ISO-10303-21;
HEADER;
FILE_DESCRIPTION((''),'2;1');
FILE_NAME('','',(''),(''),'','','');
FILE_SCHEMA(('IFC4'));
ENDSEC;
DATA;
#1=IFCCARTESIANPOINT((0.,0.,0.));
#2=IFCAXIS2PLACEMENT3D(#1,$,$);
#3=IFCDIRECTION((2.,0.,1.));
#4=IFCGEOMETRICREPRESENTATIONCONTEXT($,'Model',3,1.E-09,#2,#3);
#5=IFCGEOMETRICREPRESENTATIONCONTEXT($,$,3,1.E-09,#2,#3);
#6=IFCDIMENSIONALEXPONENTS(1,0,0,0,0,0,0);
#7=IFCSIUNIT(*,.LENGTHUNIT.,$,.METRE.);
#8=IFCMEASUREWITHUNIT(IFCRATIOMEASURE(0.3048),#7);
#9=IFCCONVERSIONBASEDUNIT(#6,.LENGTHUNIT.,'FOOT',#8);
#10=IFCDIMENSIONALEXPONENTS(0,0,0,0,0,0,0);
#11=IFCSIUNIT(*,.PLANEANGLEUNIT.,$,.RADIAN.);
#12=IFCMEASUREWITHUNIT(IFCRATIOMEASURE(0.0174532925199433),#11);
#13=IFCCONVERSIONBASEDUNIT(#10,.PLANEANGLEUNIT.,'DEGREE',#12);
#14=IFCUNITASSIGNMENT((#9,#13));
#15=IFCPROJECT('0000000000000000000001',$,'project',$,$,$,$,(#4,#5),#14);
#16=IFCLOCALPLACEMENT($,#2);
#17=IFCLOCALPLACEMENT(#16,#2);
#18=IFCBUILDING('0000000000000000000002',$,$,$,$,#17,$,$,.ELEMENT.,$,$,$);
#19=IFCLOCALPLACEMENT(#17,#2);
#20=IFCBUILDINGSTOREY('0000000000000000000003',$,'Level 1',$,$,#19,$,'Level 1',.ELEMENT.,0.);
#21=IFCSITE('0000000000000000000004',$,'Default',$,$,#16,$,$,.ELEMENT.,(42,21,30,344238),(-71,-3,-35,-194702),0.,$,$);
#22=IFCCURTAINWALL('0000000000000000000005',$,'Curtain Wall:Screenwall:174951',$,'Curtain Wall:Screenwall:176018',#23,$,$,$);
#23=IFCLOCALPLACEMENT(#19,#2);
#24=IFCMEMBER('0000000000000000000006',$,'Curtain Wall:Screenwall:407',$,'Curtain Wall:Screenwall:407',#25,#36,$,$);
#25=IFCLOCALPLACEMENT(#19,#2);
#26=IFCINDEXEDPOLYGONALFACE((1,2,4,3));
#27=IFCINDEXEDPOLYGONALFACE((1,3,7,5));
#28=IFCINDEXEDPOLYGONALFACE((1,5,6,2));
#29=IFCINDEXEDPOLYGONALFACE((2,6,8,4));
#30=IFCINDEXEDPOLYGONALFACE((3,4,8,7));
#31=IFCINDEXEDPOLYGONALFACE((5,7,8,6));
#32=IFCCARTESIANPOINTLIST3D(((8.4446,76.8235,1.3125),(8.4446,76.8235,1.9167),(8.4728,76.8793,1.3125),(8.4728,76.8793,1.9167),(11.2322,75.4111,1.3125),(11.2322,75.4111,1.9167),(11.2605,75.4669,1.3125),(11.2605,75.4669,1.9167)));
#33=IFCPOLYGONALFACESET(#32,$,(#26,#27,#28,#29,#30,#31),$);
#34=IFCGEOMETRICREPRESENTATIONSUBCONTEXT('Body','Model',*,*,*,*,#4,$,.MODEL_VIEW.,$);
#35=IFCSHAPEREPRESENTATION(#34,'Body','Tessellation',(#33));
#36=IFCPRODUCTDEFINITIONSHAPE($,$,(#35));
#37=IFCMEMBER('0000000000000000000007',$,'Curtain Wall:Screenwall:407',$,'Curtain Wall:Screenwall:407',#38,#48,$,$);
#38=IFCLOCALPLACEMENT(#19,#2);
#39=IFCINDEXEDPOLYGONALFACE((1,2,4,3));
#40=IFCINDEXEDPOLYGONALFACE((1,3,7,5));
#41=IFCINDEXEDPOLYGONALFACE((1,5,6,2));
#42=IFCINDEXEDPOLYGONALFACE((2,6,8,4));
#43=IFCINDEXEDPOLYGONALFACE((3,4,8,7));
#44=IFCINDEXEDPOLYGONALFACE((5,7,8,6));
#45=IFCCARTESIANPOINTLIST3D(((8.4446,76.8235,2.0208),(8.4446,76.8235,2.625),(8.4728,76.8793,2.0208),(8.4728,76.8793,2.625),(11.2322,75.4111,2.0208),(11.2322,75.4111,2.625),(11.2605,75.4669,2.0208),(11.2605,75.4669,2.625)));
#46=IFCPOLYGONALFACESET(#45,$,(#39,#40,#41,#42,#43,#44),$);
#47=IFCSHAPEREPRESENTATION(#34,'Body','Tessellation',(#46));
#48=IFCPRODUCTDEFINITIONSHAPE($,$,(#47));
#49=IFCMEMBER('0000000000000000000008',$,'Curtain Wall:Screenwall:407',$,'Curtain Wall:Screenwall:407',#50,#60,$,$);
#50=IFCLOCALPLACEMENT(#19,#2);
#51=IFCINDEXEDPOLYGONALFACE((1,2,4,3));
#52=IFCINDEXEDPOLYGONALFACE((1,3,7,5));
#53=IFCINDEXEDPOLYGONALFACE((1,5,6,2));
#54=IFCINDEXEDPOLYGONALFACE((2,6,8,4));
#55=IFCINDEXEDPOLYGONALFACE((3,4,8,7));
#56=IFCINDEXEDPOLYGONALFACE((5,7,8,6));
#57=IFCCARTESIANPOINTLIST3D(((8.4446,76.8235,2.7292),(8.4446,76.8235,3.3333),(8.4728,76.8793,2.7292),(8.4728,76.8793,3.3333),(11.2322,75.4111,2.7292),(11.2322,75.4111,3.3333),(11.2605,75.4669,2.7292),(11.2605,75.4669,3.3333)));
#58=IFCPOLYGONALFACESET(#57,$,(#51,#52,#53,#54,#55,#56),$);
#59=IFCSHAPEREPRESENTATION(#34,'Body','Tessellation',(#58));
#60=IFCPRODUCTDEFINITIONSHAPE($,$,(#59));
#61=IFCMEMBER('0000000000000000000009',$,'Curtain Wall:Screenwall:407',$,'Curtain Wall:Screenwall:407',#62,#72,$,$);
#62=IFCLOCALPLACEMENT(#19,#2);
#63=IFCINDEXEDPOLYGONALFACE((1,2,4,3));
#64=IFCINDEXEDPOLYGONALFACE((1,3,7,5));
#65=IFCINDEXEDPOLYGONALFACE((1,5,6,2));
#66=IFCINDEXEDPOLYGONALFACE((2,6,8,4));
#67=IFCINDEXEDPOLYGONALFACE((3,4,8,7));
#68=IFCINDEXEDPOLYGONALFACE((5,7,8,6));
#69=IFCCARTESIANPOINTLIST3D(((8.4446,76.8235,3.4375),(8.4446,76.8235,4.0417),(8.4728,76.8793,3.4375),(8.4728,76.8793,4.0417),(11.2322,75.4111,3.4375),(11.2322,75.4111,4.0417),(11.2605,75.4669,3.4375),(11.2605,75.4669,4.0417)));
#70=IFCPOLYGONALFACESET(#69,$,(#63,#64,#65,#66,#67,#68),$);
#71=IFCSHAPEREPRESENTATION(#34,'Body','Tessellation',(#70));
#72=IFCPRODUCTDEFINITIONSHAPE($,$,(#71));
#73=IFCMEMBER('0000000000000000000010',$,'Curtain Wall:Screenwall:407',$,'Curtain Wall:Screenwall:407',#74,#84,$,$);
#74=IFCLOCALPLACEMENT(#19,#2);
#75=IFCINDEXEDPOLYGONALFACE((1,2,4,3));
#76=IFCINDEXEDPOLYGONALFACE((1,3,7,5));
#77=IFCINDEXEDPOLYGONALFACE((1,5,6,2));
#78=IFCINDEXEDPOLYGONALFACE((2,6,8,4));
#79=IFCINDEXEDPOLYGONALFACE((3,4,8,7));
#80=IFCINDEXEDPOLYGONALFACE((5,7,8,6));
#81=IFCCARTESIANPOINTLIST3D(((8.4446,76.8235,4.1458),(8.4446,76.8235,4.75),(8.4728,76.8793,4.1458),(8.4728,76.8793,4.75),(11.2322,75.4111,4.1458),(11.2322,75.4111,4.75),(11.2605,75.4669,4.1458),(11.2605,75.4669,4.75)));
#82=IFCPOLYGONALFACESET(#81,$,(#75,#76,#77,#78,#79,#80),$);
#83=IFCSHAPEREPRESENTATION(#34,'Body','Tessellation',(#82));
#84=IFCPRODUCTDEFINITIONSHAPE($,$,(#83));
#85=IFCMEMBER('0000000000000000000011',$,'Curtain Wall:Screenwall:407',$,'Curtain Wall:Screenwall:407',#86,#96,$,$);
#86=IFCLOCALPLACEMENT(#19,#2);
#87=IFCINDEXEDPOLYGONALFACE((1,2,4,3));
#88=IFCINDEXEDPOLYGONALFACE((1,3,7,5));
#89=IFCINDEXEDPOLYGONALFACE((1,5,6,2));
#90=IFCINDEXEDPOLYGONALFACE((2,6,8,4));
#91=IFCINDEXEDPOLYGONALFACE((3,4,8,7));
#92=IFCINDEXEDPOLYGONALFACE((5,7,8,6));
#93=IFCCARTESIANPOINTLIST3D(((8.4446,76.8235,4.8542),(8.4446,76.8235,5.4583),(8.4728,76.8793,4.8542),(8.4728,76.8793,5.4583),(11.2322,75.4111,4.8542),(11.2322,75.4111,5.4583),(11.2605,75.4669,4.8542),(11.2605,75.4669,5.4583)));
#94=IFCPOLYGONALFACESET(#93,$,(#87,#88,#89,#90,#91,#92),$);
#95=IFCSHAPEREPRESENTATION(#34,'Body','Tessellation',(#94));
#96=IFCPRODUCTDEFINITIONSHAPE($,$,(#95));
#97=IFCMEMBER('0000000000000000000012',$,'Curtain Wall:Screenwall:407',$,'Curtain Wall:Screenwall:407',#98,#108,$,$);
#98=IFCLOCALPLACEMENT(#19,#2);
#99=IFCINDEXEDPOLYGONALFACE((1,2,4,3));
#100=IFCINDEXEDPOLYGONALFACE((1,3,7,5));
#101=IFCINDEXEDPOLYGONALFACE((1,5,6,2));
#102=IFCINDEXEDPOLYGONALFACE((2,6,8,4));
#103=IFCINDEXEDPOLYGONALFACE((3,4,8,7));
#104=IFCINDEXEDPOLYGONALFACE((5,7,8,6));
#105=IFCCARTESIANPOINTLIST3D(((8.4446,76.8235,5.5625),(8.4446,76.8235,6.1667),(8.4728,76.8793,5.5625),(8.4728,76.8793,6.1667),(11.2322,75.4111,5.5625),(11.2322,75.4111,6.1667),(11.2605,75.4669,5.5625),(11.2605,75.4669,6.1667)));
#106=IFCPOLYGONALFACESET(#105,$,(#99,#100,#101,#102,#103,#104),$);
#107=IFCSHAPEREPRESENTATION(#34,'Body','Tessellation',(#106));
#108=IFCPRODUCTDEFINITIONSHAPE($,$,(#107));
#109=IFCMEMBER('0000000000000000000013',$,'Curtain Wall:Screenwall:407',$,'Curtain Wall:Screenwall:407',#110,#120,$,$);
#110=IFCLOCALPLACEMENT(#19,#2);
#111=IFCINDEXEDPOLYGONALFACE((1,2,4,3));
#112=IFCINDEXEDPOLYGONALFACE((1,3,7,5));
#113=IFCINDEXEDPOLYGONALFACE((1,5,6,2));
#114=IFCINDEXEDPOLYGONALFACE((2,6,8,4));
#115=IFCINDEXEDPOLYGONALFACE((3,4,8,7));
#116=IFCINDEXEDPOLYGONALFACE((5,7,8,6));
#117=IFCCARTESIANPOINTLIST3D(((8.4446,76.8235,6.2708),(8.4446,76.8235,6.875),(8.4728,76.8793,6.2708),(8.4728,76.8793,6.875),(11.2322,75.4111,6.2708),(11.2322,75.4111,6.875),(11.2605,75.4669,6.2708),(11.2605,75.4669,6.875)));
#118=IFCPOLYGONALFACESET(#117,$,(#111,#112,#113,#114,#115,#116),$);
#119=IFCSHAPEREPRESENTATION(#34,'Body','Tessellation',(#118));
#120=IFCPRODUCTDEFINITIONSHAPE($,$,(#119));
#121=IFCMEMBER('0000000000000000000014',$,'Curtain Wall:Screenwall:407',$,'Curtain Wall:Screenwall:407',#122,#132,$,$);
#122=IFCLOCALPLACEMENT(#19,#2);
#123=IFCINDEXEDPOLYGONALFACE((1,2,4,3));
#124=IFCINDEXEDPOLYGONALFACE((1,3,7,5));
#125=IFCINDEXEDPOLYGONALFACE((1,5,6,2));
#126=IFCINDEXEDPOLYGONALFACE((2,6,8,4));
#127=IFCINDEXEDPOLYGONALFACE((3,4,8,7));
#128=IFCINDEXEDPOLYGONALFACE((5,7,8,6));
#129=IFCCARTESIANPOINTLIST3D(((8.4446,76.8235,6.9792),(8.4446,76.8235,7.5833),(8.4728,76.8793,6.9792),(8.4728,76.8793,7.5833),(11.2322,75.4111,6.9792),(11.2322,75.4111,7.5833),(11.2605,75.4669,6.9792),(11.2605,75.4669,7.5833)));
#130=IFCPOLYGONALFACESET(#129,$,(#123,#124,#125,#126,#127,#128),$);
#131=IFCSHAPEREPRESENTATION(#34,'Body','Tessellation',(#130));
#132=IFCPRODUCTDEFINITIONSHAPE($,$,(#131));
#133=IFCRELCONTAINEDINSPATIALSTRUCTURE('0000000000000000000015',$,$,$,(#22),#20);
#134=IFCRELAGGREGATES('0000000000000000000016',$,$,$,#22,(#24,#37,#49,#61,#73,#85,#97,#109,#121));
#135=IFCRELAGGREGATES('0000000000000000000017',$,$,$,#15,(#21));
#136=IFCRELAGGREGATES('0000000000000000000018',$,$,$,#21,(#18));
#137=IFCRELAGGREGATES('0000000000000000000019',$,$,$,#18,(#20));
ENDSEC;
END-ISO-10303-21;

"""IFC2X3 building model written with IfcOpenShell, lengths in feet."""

from ifc_helpers import new_model, entity, si_unit, converted_unit, direction, frame, frame_2d, origin, place, context, subcontext, project, spatial, rectangle, extrude, element, aggregate, save


model = new_model("IFC2X3")

# Units and contexts
model_context = context("Model", 3, precision=1e-09, world=origin(), true_north=direction((2.0, 0.0, 1.0)))
context_of_model = context(None, 3, precision=1e-09, world=origin(), true_north=direction((2.0, 0.0, 1.0)))
body_context = subcontext(model_context, "Body", "Model", "MODEL_VIEW")
ifc_project = project(units=[converted_unit("LENGTHUNIT", "FOOT", entity("IfcRatioMeasure", 0.3048), si_unit("LENGTHUNIT", "METRE"), dimensions=[1, 0, 0, 0, 0, 0, 0]), converted_unit("PLANEANGLEUNIT", "DEGREE", entity("IfcRatioMeasure", 0.0174532925199433), si_unit("PLANEANGLEUNIT", "RADIAN"), dimensions=[0, 0, 0, 0, 0, 0, 0])], contexts=[model_context, context_of_model])

# Site, building, storey
site_placement = place(None, origin())
site = spatial("IfcSite", under=ifc_project, at=site_placement, Name="Default", CompositionType="ELEMENT", RefLatitude=(42, 21, 30, 344238), RefLongitude=(-71, -3, -35, -194702), RefElevation=0.0)
building_placement = place(site_placement, origin())
building = spatial("IfcBuilding", under=site, at=building_placement, CompositionType="ELEMENT")
storey_placement = place(building_placement, origin())
storey = spatial("IfcBuildingStorey", under=building, at=storey_placement, Name="Level 1", LongName="Level 1", CompositionType="ELEMENT", Elevation=0.0)

# Curtain wall, members
curtain_wall_placement = place(storey_placement, origin())
curtain_wall = element("IfcCurtainWall", 1, at=curtain_wall_placement, inside=storey, Name="Curtain Wall:Screenwall:174951", ObjectType="Curtain Wall:Screenwall:176018")
member_1_placement = place(curtain_wall_placement, frame((8.4446, 75.4111, 1.3125)))
member_1 = element("IfcMember", 2, at=member_1_placement, Name="Curtain Wall:Screenwall:407", ObjectType="Curtain Wall:Screenwall:407", context=body_context, shape_type="SweptSolid", body=[
    extrude(rectangle(XDim=3.1251, YDim=0.0625, at=frame_2d((0.0, 0.0), x_axis=(1.0, 0.0))), frame((1.408, 0.7341, 0.0), z_axis=(0.0, 0.0, 1.0), x_axis=(0.892035, -0.451966, 0.0)), (0.0, 0.0, 1.0), 0.6042),
])
member_2_placement = place(curtain_wall_placement, frame((8.4446, 75.4111, 2.0208)))
member_2 = element("IfcMember", 3, at=member_2_placement, Name="Curtain Wall:Screenwall:407", ObjectType="Curtain Wall:Screenwall:407", context=body_context, shape_type="SweptSolid", body=[
    extrude(rectangle(XDim=3.1251, YDim=0.0625, at=frame_2d((0.0, 0.0), x_axis=(1.0, 0.0))), frame((1.408, 0.7341, 0.0), z_axis=(0.0, 0.0, 1.0), x_axis=(0.892035, -0.451966, 0.0)), (0.0, 0.0, 1.0), 0.6042),
])
member_3_placement = place(curtain_wall_placement, frame((8.4446, 75.4111, 2.7292)))
member_3 = element("IfcMember", 4, at=member_3_placement, Name="Curtain Wall:Screenwall:407", ObjectType="Curtain Wall:Screenwall:407", context=body_context, shape_type="SweptSolid", body=[
    extrude(rectangle(XDim=3.1251, YDim=0.0625, at=frame_2d((0.0, 0.0), x_axis=(1.0, 0.0))), frame((1.408, 0.7341, 0.0), z_axis=(0.0, 0.0, 1.0), x_axis=(0.892035, -0.451966, 0.0)), (0.0, 0.0, 1.0), 0.6042),
])
member_4_placement = place(curtain_wall_placement, frame((8.4446, 75.4111, 3.4375)))
member_4 = element("IfcMember", 5, at=member_4_placement, Name="Curtain Wall:Screenwall:407", ObjectType="Curtain Wall:Screenwall:407", context=body_context, shape_type="SweptSolid", body=[
    extrude(rectangle(XDim=3.1251, YDim=0.0625, at=frame_2d((0.0, 0.0), x_axis=(1.0, 0.0))), frame((1.408, 0.7341, 0.0), z_axis=(0.0, 0.0, 1.0), x_axis=(0.892035, -0.451966, 0.0)), (0.0, 0.0, 1.0), 0.6042),
])
member_5_placement = place(curtain_wall_placement, frame((8.4446, 75.4111, 4.1458)))
member_5 = element("IfcMember", 6, at=member_5_placement, Name="Curtain Wall:Screenwall:407", ObjectType="Curtain Wall:Screenwall:407", context=body_context, shape_type="SweptSolid", body=[
    extrude(rectangle(XDim=3.1251, YDim=0.0625, at=frame_2d((0.0, 0.0), x_axis=(1.0, 0.0))), frame((1.408, 0.7341, 0.0), z_axis=(0.0, 0.0, 1.0), x_axis=(0.892035, -0.451966, 0.0)), (0.0, 0.0, 1.0), 0.6042),
])
member_6_placement = place(curtain_wall_placement, frame((8.4446, 75.4111, 4.8542)))
member_6 = element("IfcMember", 7, at=member_6_placement, Name="Curtain Wall:Screenwall:407", ObjectType="Curtain Wall:Screenwall:407", context=body_context, shape_type="SweptSolid", body=[
    extrude(rectangle(XDim=3.1251, YDim=0.0625, at=frame_2d((0.0, 0.0), x_axis=(1.0, 0.0))), frame((1.408, 0.7341, 0.0), z_axis=(0.0, 0.0, 1.0), x_axis=(0.892035, -0.451966, 0.0)), (0.0, 0.0, 1.0), 0.6042),
])
member_7_placement = place(curtain_wall_placement, frame((8.4446, 75.4111, 5.5625)))
member_7 = element("IfcMember", 8, at=member_7_placement, Name="Curtain Wall:Screenwall:407", ObjectType="Curtain Wall:Screenwall:407", context=body_context, shape_type="SweptSolid", body=[
    extrude(rectangle(XDim=3.1251, YDim=0.0625, at=frame_2d((0.0, 0.0), x_axis=(1.0, 0.0))), frame((1.408, 0.7341, 0.0), z_axis=(0.0, 0.0, 1.0), x_axis=(0.892035, -0.451966, 0.0)), (0.0, 0.0, 1.0), 0.6042),
])
member_8_placement = place(curtain_wall_placement, frame((8.4446, 75.4111, 6.2708)))
member_8 = element("IfcMember", 9, at=member_8_placement, Name="Curtain Wall:Screenwall:407", ObjectType="Curtain Wall:Screenwall:407", context=body_context, shape_type="SweptSolid", body=[
    extrude(rectangle(XDim=3.1251, YDim=0.0625, at=frame_2d((0.0, 0.0), x_axis=(1.0, 0.0))), frame((1.408, 0.7341, 0.0), z_axis=(0.0, 0.0, 1.0), x_axis=(0.892035, -0.451966, 0.0)), (0.0, 0.0, 1.0), 0.6042),
])
member_9_placement = place(curtain_wall_placement, frame((8.4446, 75.4111, 6.9792)))
member_9 = element("IfcMember", 10, at=member_9_placement, Name="Curtain Wall:Screenwall:407", ObjectType="Curtain Wall:Screenwall:407", context=body_context, shape_type="SweptSolid", body=[
    extrude(rectangle(XDim=3.1251, YDim=0.0625, at=frame_2d((0.0, 0.0), x_axis=(1.0, 0.0))), frame((1.408, 0.7341, 0.0), z_axis=(0.0, 0.0, 1.0), x_axis=(0.892035, -0.451966, 0.0)), (0.0, 0.0, 1.0), 0.6042),
])
aggregate(curtain_wall, [member_1, member_2, member_3, member_4, member_5, member_6, member_7, member_8, member_9])

save(model, "model.ifc")
